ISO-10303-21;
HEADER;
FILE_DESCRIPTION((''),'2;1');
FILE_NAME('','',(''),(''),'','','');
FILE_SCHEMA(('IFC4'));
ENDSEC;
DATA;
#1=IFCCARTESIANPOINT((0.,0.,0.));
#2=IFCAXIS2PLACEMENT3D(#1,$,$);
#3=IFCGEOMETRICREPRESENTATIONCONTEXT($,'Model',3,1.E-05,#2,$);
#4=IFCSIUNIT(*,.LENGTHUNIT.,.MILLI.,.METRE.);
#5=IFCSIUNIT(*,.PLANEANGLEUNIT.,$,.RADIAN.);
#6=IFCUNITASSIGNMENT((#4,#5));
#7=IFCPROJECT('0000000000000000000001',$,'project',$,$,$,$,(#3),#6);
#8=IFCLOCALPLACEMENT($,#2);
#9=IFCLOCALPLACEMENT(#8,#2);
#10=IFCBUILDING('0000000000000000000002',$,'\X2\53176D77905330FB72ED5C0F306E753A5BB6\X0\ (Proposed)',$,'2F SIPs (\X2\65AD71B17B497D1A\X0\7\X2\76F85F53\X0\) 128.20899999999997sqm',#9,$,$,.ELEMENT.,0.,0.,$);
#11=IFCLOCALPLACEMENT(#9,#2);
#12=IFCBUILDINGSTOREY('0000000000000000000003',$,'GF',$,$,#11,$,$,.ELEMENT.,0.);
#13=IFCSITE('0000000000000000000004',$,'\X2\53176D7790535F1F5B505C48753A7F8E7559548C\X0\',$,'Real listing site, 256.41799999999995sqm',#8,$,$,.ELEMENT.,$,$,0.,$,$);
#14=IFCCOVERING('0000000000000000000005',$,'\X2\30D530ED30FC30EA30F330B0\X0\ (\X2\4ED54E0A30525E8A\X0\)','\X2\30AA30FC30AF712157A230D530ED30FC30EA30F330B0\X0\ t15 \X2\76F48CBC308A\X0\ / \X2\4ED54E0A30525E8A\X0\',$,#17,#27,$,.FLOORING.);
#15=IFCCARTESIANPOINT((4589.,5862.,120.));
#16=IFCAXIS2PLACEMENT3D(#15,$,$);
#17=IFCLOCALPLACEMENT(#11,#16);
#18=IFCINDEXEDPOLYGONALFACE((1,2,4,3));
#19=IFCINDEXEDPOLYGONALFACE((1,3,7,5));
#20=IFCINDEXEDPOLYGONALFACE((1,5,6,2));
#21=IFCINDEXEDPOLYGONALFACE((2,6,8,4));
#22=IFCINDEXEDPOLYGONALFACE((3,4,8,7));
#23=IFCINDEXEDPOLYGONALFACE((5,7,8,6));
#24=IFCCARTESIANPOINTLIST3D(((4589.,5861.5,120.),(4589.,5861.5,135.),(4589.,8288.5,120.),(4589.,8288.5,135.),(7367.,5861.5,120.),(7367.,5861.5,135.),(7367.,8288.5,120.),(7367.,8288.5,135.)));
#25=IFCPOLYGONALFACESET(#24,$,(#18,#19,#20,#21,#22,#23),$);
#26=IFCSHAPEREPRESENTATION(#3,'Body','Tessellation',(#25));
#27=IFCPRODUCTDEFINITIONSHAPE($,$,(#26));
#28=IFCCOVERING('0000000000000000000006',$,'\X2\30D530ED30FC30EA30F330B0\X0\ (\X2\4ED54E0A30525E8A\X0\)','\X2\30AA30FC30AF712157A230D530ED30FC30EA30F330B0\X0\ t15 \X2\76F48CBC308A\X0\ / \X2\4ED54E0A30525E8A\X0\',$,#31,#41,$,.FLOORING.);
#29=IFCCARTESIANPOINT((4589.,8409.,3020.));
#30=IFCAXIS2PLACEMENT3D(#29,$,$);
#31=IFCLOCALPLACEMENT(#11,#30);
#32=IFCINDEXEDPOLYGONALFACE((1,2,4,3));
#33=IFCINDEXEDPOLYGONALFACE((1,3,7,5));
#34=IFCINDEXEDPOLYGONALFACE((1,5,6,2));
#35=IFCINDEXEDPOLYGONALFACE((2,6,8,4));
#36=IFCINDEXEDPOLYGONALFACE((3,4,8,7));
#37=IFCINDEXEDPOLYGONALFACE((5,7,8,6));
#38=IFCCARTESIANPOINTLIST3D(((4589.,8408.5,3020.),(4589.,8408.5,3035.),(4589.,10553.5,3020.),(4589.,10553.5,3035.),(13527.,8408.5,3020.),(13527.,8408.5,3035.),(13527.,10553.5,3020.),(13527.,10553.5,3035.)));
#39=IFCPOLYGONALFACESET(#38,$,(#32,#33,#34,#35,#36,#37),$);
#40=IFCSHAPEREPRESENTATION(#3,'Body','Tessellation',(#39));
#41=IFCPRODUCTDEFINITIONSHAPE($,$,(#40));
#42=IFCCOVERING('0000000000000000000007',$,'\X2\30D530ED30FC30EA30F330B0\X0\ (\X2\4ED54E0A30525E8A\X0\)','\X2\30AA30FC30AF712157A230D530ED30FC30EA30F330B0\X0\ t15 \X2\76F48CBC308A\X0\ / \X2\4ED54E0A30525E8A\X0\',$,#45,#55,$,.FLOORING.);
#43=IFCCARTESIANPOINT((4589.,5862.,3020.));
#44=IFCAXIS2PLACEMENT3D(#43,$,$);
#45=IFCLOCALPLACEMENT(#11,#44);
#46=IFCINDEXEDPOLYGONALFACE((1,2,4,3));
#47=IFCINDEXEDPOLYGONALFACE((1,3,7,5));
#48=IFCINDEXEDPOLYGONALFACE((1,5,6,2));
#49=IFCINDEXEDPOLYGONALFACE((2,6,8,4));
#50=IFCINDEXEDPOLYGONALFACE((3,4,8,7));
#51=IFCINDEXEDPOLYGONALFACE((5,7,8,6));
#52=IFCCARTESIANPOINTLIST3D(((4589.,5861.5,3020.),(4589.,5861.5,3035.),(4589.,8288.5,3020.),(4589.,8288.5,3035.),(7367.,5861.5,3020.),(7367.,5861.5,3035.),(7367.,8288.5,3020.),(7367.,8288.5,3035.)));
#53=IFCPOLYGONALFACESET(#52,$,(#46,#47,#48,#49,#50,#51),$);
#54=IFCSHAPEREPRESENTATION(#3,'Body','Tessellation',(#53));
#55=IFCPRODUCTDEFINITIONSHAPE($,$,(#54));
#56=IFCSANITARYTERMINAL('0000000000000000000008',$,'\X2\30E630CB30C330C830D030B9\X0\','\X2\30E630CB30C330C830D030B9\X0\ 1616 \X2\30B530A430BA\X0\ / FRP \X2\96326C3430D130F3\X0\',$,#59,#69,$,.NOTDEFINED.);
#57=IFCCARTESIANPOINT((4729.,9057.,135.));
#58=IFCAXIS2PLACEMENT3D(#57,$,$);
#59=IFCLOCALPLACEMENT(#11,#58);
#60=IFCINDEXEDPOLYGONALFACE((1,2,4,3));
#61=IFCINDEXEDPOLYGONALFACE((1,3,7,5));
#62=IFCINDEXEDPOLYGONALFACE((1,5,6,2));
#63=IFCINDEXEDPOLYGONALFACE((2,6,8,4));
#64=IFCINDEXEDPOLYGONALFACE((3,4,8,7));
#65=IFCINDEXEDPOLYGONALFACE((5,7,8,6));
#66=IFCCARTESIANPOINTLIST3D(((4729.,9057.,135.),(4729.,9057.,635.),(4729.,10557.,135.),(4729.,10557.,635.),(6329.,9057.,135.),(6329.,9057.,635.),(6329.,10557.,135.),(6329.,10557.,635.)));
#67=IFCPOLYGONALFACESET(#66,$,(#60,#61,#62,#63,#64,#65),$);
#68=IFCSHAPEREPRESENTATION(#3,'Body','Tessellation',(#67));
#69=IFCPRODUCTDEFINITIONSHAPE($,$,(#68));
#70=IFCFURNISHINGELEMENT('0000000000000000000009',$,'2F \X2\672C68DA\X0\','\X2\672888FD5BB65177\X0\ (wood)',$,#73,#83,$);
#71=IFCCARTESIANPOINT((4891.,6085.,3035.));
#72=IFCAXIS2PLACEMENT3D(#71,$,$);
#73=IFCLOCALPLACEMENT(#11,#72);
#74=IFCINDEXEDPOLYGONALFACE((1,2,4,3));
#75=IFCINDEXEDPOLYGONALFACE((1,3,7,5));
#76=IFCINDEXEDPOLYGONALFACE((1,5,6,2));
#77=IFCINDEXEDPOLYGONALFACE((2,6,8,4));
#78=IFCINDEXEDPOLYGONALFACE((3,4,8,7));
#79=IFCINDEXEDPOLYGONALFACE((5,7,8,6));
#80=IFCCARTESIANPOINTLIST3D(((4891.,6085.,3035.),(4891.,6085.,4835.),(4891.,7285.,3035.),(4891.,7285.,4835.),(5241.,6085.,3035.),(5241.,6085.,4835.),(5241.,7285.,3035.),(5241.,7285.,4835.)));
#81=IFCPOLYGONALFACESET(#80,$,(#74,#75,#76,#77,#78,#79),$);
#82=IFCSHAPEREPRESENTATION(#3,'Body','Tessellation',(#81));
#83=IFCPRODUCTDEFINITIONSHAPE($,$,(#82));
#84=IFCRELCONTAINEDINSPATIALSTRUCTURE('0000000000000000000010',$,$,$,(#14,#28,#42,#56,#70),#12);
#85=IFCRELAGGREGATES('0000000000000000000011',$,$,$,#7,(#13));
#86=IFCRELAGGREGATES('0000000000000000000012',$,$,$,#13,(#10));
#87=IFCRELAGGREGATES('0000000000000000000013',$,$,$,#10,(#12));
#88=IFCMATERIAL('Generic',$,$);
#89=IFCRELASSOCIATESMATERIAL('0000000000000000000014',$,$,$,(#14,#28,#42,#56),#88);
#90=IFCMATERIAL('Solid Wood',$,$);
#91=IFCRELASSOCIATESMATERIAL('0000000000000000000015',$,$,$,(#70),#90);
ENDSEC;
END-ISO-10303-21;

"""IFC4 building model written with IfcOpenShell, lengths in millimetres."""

from ifc_helpers import new_model, si_unit, frame, frame_2d, origin, place, context, project, spatial, rectangle, extrude, material, element, save


model = new_model("IFC4")

# Units and contexts
model_context = context("Model", 3, precision=1e-05, world=origin())
ifc_project = project(units=[si_unit("LENGTHUNIT", "METRE", prefix="MILLI"), si_unit("PLANEANGLEUNIT", "RADIAN")], contexts=[model_context])

# Site, building, storey
site_placement = place(None, origin())
site = spatial("IfcSite", under=ifc_project, at=site_placement, Name="北海道弟子屈町美留和", ObjectType="Real listing site, 256.41799999999995sqm", CompositionType="ELEMENT", RefElevation=0.0)
building_placement = place(site_placement, origin())
building = spatial("IfcBuilding", under=site, at=building_placement, Name="北海道・狭小の町家 (Proposed)", ObjectType="2F SIPs (断熱等級7相当) 128.20899999999997sqm", CompositionType="ELEMENT", ElevationOfRefHeight=0.0, ElevationOfTerrain=0.0)
storey_placement = place(building_placement, origin())
storey = spatial("IfcBuildingStorey", under=building, at=storey_placement, Name="GF", CompositionType="ELEMENT", Elevation=0.0)

# Shared definitions
ifc_material_1 = material(Name="Solid Wood")

# Coverings
ifc_material_2 = material(Name="Generic")
covering_1_placement = place(storey_placement, frame((4589.0, 5862.0, 120.0)))
element("IfcCovering", 1, at=covering_1_placement, inside=storey, material=ifc_material_2, Name="フローリング (仕上げ床)", Description="オーク無垢フローリング t15 直貼り / 仕上げ床", PredefinedType="FLOORING", context=model_context, shape_type="SweptSolid", body=[
    extrude(rectangle(XDim=2778.0, YDim=2427.0, at=frame_2d((1389.0, 1213.0))), frame((4589.0, 5862.0, 120.0)), (0.0, 0.0, 1.0), 15.0),
])
covering_2_placement = place(storey_placement, frame((4589.0, 8409.0, 3020.0)))
element("IfcCovering", 2, at=covering_2_placement, inside=storey, material=ifc_material_2, Name="フローリング (仕上げ床)", Description="オーク無垢フローリング t15 直貼り / 仕上げ床", PredefinedType="FLOORING", context=model_context, shape_type="SweptSolid", body=[
    extrude(rectangle(XDim=8938.0, YDim=2145.0, at=frame_2d((4469.0, 1072.0))), frame((4589.0, 8409.0, 3020.0)), (0.0, 0.0, 1.0), 15.0),
])
covering_3_placement = place(storey_placement, frame((4589.0, 5862.0, 3020.0)))
element("IfcCovering", 3, at=covering_3_placement, inside=storey, material=ifc_material_2, Name="フローリング (仕上げ床)", Description="オーク無垢フローリング t15 直貼り / 仕上げ床", PredefinedType="FLOORING", context=model_context, shape_type="SweptSolid", body=[
    extrude(rectangle(XDim=2778.0, YDim=2427.0, at=frame_2d((1389.0, 1213.0))), frame((4589.0, 5862.0, 3020.0)), (0.0, 0.0, 1.0), 15.0),
])

# Sanitary terminal
sanitary_terminal_placement = place(storey_placement, frame((4729.0, 9057.0, 135.0)))
element("IfcSanitaryTerminal", 4, at=sanitary_terminal_placement, inside=storey, material=ifc_material_2, Name="ユニットバス", Description="ユニットバス 1616 サイズ / FRP 防水パン", PredefinedType="NOTDEFINED", context=model_context, shape_type="SweptSolid", body=[
    extrude(rectangle(XDim=1600.0, YDim=1500.0, at=frame_2d((800.0, 750.0))), frame((4729.0, 9057.0, 135.0)), (0.0, 0.0, 1.0), 500.0),
])

# Furnishing element
furnishing_placement = place(storey_placement, frame((4891.0, 6085.0, 3035.0)))
element("IfcFurnishingElement", 5, at=furnishing_placement, inside=storey, material=ifc_material_1, Name="2F 本棚", Description="木製家具 (wood)", context=model_context, shape_type="SweptSolid", body=[
    extrude(rectangle(XDim=350.0, YDim=1200.0, at=frame_2d((175.0, 600.0))), frame((4891.0, 6085.0, 3035.0)), (0.0, 0.0, 1.0), 1800.0),
])

save(model, "model.ifc")
